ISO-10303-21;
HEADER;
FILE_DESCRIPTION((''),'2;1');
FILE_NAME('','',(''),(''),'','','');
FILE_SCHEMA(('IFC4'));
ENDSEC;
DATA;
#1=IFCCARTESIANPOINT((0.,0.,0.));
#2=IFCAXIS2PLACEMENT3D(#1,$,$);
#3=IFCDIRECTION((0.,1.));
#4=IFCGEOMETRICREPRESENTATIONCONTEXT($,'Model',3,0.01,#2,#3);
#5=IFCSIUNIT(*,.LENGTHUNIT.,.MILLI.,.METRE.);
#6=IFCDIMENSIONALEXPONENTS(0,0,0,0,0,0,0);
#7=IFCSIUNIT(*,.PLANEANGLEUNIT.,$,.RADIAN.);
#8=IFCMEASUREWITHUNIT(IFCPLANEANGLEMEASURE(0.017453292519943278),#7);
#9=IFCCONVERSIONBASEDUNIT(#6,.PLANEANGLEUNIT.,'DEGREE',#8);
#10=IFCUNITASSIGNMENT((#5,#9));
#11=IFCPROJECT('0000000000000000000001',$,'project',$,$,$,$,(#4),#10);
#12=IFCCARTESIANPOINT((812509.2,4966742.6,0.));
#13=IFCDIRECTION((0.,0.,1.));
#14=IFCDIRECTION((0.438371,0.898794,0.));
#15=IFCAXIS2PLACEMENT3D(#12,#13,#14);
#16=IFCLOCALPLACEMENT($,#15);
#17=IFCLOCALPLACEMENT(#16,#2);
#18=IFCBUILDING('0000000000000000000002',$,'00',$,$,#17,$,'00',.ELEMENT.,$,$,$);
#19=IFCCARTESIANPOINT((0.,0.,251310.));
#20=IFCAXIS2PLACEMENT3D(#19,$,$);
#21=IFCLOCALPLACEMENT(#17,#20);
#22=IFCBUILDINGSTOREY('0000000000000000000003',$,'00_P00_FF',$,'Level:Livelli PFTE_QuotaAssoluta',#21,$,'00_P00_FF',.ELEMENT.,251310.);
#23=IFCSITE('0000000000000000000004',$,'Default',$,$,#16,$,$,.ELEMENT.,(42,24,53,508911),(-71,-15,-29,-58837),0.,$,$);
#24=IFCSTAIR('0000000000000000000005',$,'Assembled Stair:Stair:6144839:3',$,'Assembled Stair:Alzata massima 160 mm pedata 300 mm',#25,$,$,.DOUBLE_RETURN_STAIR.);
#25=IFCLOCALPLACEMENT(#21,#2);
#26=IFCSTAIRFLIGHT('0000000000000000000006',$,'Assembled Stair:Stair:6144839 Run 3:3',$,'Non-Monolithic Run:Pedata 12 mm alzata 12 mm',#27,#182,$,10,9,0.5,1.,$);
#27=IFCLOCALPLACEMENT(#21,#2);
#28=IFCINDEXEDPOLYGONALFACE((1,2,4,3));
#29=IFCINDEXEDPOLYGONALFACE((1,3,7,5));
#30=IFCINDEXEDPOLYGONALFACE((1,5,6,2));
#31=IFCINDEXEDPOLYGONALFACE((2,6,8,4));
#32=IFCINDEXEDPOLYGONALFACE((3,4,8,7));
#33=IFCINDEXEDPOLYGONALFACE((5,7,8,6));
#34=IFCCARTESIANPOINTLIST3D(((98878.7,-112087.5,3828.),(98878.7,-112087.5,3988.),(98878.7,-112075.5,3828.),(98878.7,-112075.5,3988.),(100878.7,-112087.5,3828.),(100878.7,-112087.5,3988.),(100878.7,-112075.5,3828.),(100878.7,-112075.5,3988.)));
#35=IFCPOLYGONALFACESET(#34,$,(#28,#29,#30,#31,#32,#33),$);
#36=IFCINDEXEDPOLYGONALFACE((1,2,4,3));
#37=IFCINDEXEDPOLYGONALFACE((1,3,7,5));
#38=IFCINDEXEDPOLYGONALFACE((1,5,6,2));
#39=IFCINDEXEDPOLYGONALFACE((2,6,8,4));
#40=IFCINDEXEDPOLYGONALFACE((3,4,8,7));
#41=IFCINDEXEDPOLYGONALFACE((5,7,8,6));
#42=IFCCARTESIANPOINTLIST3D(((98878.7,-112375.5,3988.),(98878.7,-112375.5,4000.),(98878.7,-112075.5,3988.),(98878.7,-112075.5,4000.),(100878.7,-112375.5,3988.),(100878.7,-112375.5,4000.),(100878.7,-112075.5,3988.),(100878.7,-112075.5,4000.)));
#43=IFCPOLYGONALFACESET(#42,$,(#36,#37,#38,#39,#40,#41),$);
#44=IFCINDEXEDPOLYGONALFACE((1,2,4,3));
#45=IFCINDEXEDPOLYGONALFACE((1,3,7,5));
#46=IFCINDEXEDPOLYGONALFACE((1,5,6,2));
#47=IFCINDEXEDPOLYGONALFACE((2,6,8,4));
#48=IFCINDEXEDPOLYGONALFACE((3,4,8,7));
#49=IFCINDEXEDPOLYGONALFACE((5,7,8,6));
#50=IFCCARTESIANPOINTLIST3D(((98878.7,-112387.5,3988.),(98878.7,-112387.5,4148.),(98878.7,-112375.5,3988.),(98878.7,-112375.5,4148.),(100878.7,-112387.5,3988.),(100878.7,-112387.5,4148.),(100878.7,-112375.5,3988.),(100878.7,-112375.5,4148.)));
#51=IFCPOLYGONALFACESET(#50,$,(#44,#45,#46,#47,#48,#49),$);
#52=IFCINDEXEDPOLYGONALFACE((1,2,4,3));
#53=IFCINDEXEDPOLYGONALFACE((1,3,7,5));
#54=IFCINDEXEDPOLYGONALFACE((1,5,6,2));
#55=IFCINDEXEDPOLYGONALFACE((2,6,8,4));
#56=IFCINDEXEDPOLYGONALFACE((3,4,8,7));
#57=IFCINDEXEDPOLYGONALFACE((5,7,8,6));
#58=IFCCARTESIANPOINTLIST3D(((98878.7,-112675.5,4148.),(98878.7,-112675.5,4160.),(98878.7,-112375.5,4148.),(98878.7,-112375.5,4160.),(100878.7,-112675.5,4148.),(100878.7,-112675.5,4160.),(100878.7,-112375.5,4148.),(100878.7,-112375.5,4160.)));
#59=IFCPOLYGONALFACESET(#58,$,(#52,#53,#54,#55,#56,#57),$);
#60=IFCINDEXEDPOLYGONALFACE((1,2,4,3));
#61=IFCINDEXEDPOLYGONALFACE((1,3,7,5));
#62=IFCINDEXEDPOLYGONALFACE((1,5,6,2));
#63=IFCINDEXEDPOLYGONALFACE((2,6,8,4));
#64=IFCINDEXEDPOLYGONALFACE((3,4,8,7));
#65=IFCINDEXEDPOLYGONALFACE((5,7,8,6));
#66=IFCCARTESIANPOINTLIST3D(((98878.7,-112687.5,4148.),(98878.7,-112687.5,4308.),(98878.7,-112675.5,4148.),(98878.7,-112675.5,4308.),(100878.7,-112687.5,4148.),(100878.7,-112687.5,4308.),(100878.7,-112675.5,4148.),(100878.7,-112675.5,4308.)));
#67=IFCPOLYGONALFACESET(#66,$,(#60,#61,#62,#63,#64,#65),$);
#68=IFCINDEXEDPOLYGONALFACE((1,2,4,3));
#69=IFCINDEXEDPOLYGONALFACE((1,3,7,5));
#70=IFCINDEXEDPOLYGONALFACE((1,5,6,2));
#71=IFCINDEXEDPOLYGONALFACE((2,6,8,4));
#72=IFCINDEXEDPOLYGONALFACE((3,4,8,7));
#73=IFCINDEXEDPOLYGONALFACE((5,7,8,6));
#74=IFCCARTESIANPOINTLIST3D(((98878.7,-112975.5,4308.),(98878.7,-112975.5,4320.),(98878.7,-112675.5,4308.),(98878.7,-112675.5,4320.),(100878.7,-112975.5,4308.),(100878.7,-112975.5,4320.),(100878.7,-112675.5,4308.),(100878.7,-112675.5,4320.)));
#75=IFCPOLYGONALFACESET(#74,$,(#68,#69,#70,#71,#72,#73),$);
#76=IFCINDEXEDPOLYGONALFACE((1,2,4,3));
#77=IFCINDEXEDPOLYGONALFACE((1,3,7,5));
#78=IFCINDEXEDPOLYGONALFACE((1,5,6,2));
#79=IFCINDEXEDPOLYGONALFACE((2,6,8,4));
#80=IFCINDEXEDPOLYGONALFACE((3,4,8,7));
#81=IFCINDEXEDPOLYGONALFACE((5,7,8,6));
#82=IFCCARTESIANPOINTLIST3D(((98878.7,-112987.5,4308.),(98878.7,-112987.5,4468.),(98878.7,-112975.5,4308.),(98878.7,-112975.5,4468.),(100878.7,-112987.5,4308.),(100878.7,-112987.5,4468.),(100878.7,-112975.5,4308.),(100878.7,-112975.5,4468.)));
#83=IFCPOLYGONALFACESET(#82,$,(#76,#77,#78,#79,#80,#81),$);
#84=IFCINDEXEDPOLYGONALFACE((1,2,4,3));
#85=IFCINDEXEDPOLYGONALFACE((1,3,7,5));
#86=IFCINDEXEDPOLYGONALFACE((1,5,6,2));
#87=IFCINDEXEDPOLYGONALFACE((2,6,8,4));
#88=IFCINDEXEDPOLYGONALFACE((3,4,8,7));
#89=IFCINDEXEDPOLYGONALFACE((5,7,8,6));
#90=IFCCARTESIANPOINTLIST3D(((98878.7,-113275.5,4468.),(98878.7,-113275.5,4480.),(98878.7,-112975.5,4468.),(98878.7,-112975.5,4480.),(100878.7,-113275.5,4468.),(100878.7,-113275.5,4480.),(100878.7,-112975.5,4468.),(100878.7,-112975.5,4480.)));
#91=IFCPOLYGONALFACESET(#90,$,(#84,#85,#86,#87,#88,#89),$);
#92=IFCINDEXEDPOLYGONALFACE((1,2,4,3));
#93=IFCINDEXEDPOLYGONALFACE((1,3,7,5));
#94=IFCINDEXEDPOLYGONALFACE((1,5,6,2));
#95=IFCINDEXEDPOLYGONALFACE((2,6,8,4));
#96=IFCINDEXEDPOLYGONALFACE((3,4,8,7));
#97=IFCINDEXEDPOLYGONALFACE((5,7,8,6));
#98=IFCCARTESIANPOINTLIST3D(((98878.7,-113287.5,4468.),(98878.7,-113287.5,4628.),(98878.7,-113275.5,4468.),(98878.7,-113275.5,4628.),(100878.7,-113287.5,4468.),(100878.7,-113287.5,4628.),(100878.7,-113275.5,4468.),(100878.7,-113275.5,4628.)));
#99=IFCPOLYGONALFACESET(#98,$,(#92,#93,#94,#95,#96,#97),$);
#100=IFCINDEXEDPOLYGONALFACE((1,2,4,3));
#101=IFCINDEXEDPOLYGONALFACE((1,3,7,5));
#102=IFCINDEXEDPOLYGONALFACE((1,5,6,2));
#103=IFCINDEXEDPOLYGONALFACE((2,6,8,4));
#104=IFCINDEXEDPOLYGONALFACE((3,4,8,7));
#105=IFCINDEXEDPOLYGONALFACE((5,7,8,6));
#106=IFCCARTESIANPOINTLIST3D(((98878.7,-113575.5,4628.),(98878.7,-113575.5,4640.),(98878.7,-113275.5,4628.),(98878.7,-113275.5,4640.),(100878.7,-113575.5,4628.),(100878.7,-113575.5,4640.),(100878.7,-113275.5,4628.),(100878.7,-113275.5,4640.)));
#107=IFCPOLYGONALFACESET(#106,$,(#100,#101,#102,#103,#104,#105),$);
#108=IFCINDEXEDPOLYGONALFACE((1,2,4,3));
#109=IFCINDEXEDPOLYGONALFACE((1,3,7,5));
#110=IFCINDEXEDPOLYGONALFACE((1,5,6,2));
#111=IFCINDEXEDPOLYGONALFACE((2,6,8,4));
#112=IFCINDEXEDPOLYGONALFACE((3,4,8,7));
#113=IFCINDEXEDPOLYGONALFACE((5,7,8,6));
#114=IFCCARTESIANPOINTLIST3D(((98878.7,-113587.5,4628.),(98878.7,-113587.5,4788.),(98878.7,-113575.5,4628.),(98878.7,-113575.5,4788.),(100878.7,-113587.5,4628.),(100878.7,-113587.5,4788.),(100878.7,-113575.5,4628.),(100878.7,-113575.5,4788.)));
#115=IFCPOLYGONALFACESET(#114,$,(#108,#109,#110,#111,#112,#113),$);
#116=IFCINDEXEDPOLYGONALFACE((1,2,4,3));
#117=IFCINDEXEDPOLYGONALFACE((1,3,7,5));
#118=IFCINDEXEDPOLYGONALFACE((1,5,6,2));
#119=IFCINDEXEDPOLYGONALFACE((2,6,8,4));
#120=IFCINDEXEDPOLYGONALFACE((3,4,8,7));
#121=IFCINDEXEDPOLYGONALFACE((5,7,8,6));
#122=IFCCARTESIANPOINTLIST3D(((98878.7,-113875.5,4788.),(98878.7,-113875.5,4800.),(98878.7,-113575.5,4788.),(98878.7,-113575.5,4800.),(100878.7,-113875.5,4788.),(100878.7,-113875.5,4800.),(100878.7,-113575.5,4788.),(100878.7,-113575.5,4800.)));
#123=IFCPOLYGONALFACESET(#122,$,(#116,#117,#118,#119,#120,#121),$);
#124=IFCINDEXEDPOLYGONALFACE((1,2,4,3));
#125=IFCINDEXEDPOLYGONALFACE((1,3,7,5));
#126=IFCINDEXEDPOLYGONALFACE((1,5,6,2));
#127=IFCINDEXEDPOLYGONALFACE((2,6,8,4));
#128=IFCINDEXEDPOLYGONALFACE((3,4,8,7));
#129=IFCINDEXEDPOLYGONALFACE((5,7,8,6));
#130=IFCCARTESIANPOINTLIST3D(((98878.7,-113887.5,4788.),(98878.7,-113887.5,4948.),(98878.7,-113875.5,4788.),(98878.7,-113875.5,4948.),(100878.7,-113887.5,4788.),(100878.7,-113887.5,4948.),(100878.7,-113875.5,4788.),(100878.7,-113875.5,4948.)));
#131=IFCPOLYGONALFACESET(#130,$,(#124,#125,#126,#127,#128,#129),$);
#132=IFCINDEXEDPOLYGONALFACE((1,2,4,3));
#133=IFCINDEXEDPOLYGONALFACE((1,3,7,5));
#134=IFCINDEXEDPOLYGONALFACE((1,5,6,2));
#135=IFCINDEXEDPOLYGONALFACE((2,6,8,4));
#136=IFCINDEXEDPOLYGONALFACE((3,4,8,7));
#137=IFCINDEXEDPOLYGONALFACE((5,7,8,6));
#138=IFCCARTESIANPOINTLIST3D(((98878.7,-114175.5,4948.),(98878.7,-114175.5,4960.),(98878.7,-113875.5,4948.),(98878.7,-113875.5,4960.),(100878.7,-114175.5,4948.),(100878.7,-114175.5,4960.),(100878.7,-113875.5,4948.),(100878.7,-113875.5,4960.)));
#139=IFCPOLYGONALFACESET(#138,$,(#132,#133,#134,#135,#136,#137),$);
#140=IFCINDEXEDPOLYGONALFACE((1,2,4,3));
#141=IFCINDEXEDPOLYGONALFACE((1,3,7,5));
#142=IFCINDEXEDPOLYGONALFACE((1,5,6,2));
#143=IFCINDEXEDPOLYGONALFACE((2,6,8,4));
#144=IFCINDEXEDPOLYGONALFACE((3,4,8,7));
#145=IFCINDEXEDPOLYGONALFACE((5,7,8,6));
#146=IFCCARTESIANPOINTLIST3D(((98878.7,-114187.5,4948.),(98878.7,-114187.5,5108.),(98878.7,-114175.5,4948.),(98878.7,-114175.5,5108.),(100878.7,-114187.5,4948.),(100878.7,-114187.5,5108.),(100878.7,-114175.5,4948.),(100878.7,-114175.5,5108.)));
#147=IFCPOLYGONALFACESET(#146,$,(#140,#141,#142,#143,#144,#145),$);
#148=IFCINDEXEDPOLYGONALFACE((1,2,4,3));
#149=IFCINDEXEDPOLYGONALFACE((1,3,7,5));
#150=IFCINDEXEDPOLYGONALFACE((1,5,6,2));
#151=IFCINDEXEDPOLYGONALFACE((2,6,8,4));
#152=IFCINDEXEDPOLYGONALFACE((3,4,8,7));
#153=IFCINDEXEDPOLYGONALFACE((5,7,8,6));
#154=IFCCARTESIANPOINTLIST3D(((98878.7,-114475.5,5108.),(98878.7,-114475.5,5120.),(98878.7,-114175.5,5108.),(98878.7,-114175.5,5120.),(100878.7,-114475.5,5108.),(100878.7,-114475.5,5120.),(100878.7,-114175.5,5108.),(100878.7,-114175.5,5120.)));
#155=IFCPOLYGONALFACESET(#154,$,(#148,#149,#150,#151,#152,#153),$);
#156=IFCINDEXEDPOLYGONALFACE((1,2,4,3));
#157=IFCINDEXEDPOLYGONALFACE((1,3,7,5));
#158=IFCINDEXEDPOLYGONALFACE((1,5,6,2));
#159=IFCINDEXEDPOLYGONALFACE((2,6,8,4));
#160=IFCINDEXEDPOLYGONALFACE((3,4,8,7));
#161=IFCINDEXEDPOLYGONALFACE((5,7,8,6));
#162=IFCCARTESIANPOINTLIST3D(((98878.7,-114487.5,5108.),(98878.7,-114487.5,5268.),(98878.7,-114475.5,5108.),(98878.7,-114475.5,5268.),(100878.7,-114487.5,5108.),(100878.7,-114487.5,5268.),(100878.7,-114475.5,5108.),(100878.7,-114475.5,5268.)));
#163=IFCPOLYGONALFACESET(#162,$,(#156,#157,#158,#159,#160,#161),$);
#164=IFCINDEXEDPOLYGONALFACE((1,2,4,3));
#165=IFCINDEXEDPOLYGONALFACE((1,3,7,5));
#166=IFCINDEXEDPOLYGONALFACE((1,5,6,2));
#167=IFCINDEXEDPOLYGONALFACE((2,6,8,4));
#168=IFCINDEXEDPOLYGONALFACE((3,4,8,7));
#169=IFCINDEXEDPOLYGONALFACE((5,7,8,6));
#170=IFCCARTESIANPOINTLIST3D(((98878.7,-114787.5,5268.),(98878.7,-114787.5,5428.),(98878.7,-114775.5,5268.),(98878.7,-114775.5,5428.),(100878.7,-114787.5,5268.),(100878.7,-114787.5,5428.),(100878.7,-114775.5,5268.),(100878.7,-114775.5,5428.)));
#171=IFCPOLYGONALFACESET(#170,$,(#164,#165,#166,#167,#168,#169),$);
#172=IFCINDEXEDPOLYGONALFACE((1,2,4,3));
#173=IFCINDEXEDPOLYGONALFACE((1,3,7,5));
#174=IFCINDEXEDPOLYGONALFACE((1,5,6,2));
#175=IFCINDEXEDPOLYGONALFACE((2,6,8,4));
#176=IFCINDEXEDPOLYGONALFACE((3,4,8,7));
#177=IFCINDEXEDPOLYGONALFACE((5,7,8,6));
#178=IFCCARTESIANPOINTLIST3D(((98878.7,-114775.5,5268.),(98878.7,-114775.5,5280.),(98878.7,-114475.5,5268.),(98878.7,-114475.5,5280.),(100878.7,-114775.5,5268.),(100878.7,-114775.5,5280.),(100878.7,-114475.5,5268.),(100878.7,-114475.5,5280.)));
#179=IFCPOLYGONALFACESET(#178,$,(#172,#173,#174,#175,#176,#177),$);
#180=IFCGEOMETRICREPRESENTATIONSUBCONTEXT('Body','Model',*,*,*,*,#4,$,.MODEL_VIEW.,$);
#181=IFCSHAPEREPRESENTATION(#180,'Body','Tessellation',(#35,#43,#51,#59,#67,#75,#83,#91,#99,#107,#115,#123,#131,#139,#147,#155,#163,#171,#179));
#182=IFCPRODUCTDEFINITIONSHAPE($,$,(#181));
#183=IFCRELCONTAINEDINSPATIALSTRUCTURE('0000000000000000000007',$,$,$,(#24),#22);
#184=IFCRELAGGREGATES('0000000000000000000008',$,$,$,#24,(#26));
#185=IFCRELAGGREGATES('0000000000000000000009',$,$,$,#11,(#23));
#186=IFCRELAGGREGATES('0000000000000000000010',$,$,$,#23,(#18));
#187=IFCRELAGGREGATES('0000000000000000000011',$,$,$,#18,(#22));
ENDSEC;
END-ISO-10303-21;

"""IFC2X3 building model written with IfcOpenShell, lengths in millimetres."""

from ifc_helpers import new_model, entity, si_unit, converted_unit, direction, frame, frame_2d, origin, origin_2d_with_axis, place, context, subcontext, project, spatial, rectangle, extrude, element, aggregate, save


model = new_model("IFC2X3")

# Units and contexts
model_context = context("Model", 3, precision=0.01, world=origin(), true_north=direction((0.0, 1.0)))
body_context = subcontext(model_context, "Body", "Model", "MODEL_VIEW")
ifc_project = project(units=[si_unit("LENGTHUNIT", "METRE", prefix="MILLI"), converted_unit("PLANEANGLEUNIT", "DEGREE", entity("IfcPlaneAngleMeasure", 0.017453292519943278), si_unit("PLANEANGLEUNIT", "RADIAN"), dimensions=[0, 0, 0, 0, 0, 0, 0])], contexts=[model_context])

# Site, building, storey
site_placement = place(None, frame((812509.2, 4966742.6, 0.0), z_axis=(0.0, 0.0, 1.0), x_axis=(0.438371, 0.898794, 0.0)))
site = spatial("IfcSite", under=ifc_project, at=site_placement, Name="Default", CompositionType="ELEMENT", RefLatitude=(42, 24, 53, 508911), RefLongitude=(-71, -15, -29, -58837), RefElevation=0.0)
building_placement = place(site_placement, origin())
building = spatial("IfcBuilding", under=site, at=building_placement, Name="00", LongName="00", CompositionType="ELEMENT")
storey_placement = place(building_placement, frame((0.0, 0.0, 251310.0)))
storey = spatial("IfcBuildingStorey", under=building, at=storey_placement, Name="00_P00_FF", ObjectType="Level:Livelli PFTE_QuotaAssoluta", LongName="00_P00_FF", CompositionType="ELEMENT", Elevation=251310.0)

# Stair
stair_1_placement = place(storey_placement, origin())
stair_1 = element("IfcStair", 1, at=stair_1_placement, inside=storey, Name="Assembled Stair:Stair:6144839:3", ObjectType="Assembled Stair:Alzata massima 160 mm pedata 300 mm", ShapeType="DOUBLE_RETURN_STAIR")

# Stair flight
stair_flight_1_placement = place(stair_1_placement, origin())
stair_flight_1 = element("IfcStairFlight", 2, at=stair_flight_1_placement, Name="Assembled Stair:Stair:6144839 Run 3:3", ObjectType="Non-Monolithic Run:Pedata 12 mm alzata 12 mm", NumberOfRiser=10, NumberOfTreads=9, RiserHeight=0.5, TreadLength=1.0, context=body_context, shape_type="SweptSolid", body=[
    extrude(rectangle(XDim=2000.0, YDim=12.0, at=origin_2d_with_axis()), frame((99878.7, -112081.5, 3828.0)), (0.0, 0.0, 1.0), 160.0),
    extrude(rectangle(XDim=300.0, YDim=2000.0, at=origin_2d_with_axis()), frame((99878.7, -112225.5, 3988.0), z_axis=(0.0, 0.0, 1.0), x_axis=(0.0, 1.0, 0.0)), (0.0, 0.0, 1.0), 12.0),
    extrude(rectangle(XDim=2000.0, YDim=12.0, at=origin_2d_with_axis()), frame((99878.7, -112381.5, 3988.0)), (0.0, 0.0, 1.0), 160.0),
    extrude(rectangle(XDim=300.0, YDim=2000.0, at=frame_2d((0.0, 0.0), x_axis=(1.0, 0.0))), frame((99878.7, -112525.5, 4148.0), z_axis=(0.0, 0.0, 1.0), x_axis=(0.0, 1.0, 0.0)), (0.0, 0.0, 1.0), 12.0),
    extrude(rectangle(XDim=2000.0, YDim=12.0, at=origin_2d_with_axis()), frame((99878.7, -112681.5, 4148.0)), (0.0, 0.0, 1.0), 160.0),
    extrude(rectangle(XDim=300.0, YDim=2000.0, at=frame_2d((0.0, 0.0), x_axis=(1.0, 0.0))), frame((99878.7, -112825.5, 4308.0), z_axis=(0.0, 0.0, 1.0), x_axis=(0.0, 1.0, 0.0)), (0.0, 0.0, 1.0), 12.0),
    extrude(rectangle(XDim=2000.0, YDim=12.0, at=origin_2d_with_axis()), frame((99878.7, -112981.5, 4308.0)), (0.0, 0.0, 1.0), 160.0),
    extrude(rectangle(XDim=300.0, YDim=2000.0, at=frame_2d((0.0, 0.0), x_axis=(1.0, 0.0))), frame((99878.7, -113125.5, 4468.0), z_axis=(0.0, 0.0, 1.0), x_axis=(0.0, 1.0, 0.0)), (0.0, 0.0, 1.0), 12.0),
    extrude(rectangle(XDim=2000.0, YDim=12.0, at=origin_2d_with_axis()), frame((99878.7, -113281.5, 4468.0)), (0.0, 0.0, 1.0), 160.0),
    extrude(rectangle(XDim=300.0, YDim=2000.0, at=frame_2d((0.0, 0.0), x_axis=(1.0, 0.0))), frame((99878.7, -113425.5, 4628.0), z_axis=(0.0, 0.0, 1.0), x_axis=(0.0, 1.0, 0.0)), (0.0, 0.0, 1.0), 12.0),
    extrude(rectangle(XDim=2000.0, YDim=12.0, at=origin_2d_with_axis()), frame((99878.7, -113581.5, 4628.0)), (0.0, 0.0, 1.0), 160.0),
    extrude(rectangle(XDim=300.0, YDim=2000.0, at=frame_2d((0.0, 0.0), x_axis=(1.0, 0.0))), frame((99878.7, -113725.5, 4788.0), z_axis=(0.0, 0.0, 1.0), x_axis=(0.0, 1.0, 0.0)), (0.0, 0.0, 1.0), 12.0),
    extrude(rectangle(XDim=2000.0, YDim=12.0, at=origin_2d_with_axis()), frame((99878.7, -113881.5, 4788.0)), (0.0, 0.0, 1.0), 160.0),
    extrude(rectangle(XDim=300.0, YDim=2000.0, at=frame_2d((0.0, 0.0), x_axis=(1.0, 0.0))), frame((99878.7, -114025.5, 4948.0), z_axis=(0.0, 0.0, 1.0), x_axis=(0.0, 1.0, 0.0)), (0.0, 0.0, 1.0), 12.0),
    extrude(rectangle(XDim=2000.0, YDim=12.0, at=origin_2d_with_axis()), frame((99878.7, -114181.5, 4948.0)), (0.0, 0.0, 1.0), 160.0),
    extrude(rectangle(XDim=300.0, YDim=2000.0, at=frame_2d((0.0, 0.0), x_axis=(1.0, 0.0))), frame((99878.7, -114325.5, 5108.0), z_axis=(0.0, 0.0, 1.0), x_axis=(0.0, 1.0, 0.0)), (0.0, 0.0, 1.0), 12.0),
    extrude(rectangle(XDim=2000.0, YDim=12.0, at=origin_2d_with_axis()), frame((99878.7, -114481.5, 5108.0)), (0.0, 0.0, 1.0), 160.0),
    extrude(rectangle(XDim=2000.0, YDim=12.0, at=origin_2d_with_axis()), frame((99878.7, -114781.5, 5268.0)), (0.0, 0.0, 1.0), 160.0),
    extrude(rectangle(XDim=300.0, YDim=2000.0, at=frame_2d((0.0, 0.0), x_axis=(1.0, 0.0))), frame((99878.7, -114625.5, 5268.0), z_axis=(0.0, 0.0, 1.0), x_axis=(0.0, 1.0, 0.0)), (0.0, 0.0, 1.0), 12.0),
])
aggregate(stair_1, [stair_flight_1])

save(model, "model.ifc")
